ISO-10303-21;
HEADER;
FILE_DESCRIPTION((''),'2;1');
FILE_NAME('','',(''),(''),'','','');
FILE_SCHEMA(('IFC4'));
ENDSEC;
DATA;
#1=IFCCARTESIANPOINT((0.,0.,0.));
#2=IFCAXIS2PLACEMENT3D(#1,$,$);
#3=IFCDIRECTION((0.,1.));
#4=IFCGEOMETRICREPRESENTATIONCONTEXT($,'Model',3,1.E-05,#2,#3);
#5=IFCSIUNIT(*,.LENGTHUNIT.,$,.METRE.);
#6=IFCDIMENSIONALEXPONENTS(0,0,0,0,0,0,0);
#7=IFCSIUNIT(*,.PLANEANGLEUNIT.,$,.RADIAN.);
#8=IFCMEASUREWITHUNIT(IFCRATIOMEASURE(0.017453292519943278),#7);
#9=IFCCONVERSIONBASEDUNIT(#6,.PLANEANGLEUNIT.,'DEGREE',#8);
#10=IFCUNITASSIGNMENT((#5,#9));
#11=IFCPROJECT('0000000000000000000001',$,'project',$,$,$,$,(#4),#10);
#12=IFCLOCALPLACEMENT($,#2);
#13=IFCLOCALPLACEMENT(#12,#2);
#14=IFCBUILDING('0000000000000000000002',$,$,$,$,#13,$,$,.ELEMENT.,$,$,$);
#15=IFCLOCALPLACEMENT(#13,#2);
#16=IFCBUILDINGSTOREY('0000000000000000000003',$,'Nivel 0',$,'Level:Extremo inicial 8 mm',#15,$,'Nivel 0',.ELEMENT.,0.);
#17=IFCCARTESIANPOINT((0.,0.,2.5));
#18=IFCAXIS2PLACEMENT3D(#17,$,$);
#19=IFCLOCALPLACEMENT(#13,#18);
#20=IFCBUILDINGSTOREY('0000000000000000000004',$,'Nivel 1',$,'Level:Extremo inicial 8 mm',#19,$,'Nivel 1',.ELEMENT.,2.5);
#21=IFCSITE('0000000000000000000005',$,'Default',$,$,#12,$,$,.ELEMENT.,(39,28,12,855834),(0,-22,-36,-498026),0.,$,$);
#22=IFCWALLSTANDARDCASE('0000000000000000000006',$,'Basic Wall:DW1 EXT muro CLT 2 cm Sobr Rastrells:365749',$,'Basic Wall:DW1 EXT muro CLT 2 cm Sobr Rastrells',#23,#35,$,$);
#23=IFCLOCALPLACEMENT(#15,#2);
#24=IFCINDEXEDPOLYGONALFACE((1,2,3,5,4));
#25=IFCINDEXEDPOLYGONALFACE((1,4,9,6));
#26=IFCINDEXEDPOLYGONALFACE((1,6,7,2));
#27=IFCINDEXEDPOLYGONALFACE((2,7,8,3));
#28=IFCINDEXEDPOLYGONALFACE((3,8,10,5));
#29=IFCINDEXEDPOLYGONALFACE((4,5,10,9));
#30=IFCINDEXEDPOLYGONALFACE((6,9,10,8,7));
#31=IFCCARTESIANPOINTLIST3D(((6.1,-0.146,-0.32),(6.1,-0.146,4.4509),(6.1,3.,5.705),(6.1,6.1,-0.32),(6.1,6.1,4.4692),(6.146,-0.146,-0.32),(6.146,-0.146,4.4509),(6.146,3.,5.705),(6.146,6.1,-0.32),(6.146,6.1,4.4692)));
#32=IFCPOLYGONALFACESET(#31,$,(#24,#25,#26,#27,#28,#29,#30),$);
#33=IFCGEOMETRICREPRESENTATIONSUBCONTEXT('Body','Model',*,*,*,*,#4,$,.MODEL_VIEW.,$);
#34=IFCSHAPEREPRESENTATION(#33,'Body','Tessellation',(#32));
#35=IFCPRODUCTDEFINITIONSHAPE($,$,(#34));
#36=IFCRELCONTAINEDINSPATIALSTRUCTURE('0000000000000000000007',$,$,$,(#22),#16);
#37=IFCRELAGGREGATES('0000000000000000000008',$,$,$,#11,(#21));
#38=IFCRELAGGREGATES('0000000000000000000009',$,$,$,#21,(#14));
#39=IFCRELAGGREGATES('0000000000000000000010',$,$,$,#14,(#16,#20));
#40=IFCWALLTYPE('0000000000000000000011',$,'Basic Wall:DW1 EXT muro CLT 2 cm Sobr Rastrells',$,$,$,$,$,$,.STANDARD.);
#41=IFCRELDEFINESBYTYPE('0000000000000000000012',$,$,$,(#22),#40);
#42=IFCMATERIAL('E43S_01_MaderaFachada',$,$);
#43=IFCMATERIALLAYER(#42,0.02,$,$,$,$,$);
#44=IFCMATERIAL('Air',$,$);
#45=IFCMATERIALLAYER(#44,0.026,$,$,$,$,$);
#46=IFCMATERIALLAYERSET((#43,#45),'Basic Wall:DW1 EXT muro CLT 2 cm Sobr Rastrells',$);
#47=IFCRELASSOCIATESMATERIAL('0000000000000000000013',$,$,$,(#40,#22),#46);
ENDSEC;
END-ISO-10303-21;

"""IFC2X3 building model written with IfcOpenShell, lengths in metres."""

from ifc_helpers import new_model, entity, si_unit, converted_unit, direction, frame, frame_2d, origin, place, context, subcontext, project, spatial, polyline, rectangle, extrude, clip, bounded_halfspace, material, layer, layer_set, layer_usage, type_object, element, save


model = new_model("IFC2X3")

# Units and contexts
model_context = context("Model", 3, precision=1e-05, world=origin(), true_north=direction((0.0, 1.0)))
body_context = subcontext(model_context, "Body", "Model", "MODEL_VIEW")
ifc_project = project(units=[si_unit("LENGTHUNIT", "METRE"), converted_unit("PLANEANGLEUNIT", "DEGREE", entity("IfcRatioMeasure", 0.017453292519943278), si_unit("PLANEANGLEUNIT", "RADIAN"), dimensions=[0, 0, 0, 0, 0, 0, 0])], contexts=[model_context])

# Site, building, storey
site_placement = place(None, origin())
site = spatial("IfcSite", under=ifc_project, at=site_placement, Name="Default", CompositionType="ELEMENT", RefLatitude=(39, 28, 12, 855834), RefLongitude=(0, -22, -36, -498026), RefElevation=0.0)
building_placement = place(site_placement, origin())
building = spatial("IfcBuilding", under=site, at=building_placement, CompositionType="ELEMENT")
storey_1_placement = place(building_placement, origin())
storey_1 = spatial("IfcBuildingStorey", under=building, at=storey_1_placement, Name="Nivel 0", ObjectType="Level:Extremo inicial 8 mm", LongName="Nivel 0", CompositionType="ELEMENT", Elevation=0.0)

# Shared definitions
storey_2_placement = place(building_placement, frame((0.0, 0.0, 2.5)))
storey_2 = spatial("IfcBuildingStorey", under=building, at=storey_2_placement, Name="Nivel 1", ObjectType="Level:Extremo inicial 8 mm", LongName="Nivel 1", CompositionType="ELEMENT", Elevation=2.5)

# Wall
ifc_material_1 = material(Name="E43S_01_MaderaFachada")
ifc_layer_1 = layer(ifc_material_1, 0.02)
ifc_material_2 = material(Name="Air")
ifc_layer_2 = layer(ifc_material_2, 0.026)
ifc_layer_set_1 = layer_set([ifc_layer_1, ifc_layer_2], Name="Basic Wall:DW1 EXT muro CLT 2 cm Sobr Rastrells")
ifc_layer_usage_1 = layer_usage(ifc_layer_set_1, "AXIS2", "NEGATIVE", 0.023)
wall_type_1 = type_object("IfcWallType", Name="Basic Wall:DW1 EXT muro CLT 2 cm Sobr Rastrells", PredefinedType="STANDARD", material=ifc_layer_set_1)
wall_1_placement = place(storey_1_placement, frame((6.123, 6.1, -0.32), z_axis=(0.0, 0.0, 1.0), x_axis=(0.0, -1.0, 0.0)))
element("IfcWallStandardCase", 1, at=wall_1_placement, inside=storey_1, type_object=wall_type_1, material=ifc_layer_usage_1, Name="Basic Wall:DW1 EXT muro CLT 2 cm Sobr Rastrells:365749", ObjectType="Basic Wall:DW1 EXT muro CLT 2 cm Sobr Rastrells", context=body_context, shape_type="Clipping", body=[
    clip(clip(extrude(rectangle(XDim=6.246, YDim=0.046, at=frame_2d((3.123, 0.0), x_axis=(-1.0, 0.0))), origin(), (0.0, 0.0, 1.0), 6.025), bounded_halfspace(frame((0.0, -0.023, 4.7892), z_axis=(-0.370288, 0.0, 0.928917), x_axis=(0.0, -1.0, 0.0)), False, frame((0.0, -0.023, 4.7892)), polyline([(0.0, 0.0), (3.1, 0.0), (3.1, 0.046), (0.0, 0.046), (0.0, 0.0)]))), bounded_halfspace(frame((3.1, -0.023, 6.025), z_axis=(0.370288, 0.0, 0.928917), x_axis=(0.0, 1.0, 0.0)), False, frame((3.1, -0.023, 6.025)), polyline([(0.0, 0.0), (3.1, 0.0), (3.146, 0.0), (3.146, 0.046), (0.0, 0.046), (0.0, 0.0)]))),
])

save(model, "model.ifc")
